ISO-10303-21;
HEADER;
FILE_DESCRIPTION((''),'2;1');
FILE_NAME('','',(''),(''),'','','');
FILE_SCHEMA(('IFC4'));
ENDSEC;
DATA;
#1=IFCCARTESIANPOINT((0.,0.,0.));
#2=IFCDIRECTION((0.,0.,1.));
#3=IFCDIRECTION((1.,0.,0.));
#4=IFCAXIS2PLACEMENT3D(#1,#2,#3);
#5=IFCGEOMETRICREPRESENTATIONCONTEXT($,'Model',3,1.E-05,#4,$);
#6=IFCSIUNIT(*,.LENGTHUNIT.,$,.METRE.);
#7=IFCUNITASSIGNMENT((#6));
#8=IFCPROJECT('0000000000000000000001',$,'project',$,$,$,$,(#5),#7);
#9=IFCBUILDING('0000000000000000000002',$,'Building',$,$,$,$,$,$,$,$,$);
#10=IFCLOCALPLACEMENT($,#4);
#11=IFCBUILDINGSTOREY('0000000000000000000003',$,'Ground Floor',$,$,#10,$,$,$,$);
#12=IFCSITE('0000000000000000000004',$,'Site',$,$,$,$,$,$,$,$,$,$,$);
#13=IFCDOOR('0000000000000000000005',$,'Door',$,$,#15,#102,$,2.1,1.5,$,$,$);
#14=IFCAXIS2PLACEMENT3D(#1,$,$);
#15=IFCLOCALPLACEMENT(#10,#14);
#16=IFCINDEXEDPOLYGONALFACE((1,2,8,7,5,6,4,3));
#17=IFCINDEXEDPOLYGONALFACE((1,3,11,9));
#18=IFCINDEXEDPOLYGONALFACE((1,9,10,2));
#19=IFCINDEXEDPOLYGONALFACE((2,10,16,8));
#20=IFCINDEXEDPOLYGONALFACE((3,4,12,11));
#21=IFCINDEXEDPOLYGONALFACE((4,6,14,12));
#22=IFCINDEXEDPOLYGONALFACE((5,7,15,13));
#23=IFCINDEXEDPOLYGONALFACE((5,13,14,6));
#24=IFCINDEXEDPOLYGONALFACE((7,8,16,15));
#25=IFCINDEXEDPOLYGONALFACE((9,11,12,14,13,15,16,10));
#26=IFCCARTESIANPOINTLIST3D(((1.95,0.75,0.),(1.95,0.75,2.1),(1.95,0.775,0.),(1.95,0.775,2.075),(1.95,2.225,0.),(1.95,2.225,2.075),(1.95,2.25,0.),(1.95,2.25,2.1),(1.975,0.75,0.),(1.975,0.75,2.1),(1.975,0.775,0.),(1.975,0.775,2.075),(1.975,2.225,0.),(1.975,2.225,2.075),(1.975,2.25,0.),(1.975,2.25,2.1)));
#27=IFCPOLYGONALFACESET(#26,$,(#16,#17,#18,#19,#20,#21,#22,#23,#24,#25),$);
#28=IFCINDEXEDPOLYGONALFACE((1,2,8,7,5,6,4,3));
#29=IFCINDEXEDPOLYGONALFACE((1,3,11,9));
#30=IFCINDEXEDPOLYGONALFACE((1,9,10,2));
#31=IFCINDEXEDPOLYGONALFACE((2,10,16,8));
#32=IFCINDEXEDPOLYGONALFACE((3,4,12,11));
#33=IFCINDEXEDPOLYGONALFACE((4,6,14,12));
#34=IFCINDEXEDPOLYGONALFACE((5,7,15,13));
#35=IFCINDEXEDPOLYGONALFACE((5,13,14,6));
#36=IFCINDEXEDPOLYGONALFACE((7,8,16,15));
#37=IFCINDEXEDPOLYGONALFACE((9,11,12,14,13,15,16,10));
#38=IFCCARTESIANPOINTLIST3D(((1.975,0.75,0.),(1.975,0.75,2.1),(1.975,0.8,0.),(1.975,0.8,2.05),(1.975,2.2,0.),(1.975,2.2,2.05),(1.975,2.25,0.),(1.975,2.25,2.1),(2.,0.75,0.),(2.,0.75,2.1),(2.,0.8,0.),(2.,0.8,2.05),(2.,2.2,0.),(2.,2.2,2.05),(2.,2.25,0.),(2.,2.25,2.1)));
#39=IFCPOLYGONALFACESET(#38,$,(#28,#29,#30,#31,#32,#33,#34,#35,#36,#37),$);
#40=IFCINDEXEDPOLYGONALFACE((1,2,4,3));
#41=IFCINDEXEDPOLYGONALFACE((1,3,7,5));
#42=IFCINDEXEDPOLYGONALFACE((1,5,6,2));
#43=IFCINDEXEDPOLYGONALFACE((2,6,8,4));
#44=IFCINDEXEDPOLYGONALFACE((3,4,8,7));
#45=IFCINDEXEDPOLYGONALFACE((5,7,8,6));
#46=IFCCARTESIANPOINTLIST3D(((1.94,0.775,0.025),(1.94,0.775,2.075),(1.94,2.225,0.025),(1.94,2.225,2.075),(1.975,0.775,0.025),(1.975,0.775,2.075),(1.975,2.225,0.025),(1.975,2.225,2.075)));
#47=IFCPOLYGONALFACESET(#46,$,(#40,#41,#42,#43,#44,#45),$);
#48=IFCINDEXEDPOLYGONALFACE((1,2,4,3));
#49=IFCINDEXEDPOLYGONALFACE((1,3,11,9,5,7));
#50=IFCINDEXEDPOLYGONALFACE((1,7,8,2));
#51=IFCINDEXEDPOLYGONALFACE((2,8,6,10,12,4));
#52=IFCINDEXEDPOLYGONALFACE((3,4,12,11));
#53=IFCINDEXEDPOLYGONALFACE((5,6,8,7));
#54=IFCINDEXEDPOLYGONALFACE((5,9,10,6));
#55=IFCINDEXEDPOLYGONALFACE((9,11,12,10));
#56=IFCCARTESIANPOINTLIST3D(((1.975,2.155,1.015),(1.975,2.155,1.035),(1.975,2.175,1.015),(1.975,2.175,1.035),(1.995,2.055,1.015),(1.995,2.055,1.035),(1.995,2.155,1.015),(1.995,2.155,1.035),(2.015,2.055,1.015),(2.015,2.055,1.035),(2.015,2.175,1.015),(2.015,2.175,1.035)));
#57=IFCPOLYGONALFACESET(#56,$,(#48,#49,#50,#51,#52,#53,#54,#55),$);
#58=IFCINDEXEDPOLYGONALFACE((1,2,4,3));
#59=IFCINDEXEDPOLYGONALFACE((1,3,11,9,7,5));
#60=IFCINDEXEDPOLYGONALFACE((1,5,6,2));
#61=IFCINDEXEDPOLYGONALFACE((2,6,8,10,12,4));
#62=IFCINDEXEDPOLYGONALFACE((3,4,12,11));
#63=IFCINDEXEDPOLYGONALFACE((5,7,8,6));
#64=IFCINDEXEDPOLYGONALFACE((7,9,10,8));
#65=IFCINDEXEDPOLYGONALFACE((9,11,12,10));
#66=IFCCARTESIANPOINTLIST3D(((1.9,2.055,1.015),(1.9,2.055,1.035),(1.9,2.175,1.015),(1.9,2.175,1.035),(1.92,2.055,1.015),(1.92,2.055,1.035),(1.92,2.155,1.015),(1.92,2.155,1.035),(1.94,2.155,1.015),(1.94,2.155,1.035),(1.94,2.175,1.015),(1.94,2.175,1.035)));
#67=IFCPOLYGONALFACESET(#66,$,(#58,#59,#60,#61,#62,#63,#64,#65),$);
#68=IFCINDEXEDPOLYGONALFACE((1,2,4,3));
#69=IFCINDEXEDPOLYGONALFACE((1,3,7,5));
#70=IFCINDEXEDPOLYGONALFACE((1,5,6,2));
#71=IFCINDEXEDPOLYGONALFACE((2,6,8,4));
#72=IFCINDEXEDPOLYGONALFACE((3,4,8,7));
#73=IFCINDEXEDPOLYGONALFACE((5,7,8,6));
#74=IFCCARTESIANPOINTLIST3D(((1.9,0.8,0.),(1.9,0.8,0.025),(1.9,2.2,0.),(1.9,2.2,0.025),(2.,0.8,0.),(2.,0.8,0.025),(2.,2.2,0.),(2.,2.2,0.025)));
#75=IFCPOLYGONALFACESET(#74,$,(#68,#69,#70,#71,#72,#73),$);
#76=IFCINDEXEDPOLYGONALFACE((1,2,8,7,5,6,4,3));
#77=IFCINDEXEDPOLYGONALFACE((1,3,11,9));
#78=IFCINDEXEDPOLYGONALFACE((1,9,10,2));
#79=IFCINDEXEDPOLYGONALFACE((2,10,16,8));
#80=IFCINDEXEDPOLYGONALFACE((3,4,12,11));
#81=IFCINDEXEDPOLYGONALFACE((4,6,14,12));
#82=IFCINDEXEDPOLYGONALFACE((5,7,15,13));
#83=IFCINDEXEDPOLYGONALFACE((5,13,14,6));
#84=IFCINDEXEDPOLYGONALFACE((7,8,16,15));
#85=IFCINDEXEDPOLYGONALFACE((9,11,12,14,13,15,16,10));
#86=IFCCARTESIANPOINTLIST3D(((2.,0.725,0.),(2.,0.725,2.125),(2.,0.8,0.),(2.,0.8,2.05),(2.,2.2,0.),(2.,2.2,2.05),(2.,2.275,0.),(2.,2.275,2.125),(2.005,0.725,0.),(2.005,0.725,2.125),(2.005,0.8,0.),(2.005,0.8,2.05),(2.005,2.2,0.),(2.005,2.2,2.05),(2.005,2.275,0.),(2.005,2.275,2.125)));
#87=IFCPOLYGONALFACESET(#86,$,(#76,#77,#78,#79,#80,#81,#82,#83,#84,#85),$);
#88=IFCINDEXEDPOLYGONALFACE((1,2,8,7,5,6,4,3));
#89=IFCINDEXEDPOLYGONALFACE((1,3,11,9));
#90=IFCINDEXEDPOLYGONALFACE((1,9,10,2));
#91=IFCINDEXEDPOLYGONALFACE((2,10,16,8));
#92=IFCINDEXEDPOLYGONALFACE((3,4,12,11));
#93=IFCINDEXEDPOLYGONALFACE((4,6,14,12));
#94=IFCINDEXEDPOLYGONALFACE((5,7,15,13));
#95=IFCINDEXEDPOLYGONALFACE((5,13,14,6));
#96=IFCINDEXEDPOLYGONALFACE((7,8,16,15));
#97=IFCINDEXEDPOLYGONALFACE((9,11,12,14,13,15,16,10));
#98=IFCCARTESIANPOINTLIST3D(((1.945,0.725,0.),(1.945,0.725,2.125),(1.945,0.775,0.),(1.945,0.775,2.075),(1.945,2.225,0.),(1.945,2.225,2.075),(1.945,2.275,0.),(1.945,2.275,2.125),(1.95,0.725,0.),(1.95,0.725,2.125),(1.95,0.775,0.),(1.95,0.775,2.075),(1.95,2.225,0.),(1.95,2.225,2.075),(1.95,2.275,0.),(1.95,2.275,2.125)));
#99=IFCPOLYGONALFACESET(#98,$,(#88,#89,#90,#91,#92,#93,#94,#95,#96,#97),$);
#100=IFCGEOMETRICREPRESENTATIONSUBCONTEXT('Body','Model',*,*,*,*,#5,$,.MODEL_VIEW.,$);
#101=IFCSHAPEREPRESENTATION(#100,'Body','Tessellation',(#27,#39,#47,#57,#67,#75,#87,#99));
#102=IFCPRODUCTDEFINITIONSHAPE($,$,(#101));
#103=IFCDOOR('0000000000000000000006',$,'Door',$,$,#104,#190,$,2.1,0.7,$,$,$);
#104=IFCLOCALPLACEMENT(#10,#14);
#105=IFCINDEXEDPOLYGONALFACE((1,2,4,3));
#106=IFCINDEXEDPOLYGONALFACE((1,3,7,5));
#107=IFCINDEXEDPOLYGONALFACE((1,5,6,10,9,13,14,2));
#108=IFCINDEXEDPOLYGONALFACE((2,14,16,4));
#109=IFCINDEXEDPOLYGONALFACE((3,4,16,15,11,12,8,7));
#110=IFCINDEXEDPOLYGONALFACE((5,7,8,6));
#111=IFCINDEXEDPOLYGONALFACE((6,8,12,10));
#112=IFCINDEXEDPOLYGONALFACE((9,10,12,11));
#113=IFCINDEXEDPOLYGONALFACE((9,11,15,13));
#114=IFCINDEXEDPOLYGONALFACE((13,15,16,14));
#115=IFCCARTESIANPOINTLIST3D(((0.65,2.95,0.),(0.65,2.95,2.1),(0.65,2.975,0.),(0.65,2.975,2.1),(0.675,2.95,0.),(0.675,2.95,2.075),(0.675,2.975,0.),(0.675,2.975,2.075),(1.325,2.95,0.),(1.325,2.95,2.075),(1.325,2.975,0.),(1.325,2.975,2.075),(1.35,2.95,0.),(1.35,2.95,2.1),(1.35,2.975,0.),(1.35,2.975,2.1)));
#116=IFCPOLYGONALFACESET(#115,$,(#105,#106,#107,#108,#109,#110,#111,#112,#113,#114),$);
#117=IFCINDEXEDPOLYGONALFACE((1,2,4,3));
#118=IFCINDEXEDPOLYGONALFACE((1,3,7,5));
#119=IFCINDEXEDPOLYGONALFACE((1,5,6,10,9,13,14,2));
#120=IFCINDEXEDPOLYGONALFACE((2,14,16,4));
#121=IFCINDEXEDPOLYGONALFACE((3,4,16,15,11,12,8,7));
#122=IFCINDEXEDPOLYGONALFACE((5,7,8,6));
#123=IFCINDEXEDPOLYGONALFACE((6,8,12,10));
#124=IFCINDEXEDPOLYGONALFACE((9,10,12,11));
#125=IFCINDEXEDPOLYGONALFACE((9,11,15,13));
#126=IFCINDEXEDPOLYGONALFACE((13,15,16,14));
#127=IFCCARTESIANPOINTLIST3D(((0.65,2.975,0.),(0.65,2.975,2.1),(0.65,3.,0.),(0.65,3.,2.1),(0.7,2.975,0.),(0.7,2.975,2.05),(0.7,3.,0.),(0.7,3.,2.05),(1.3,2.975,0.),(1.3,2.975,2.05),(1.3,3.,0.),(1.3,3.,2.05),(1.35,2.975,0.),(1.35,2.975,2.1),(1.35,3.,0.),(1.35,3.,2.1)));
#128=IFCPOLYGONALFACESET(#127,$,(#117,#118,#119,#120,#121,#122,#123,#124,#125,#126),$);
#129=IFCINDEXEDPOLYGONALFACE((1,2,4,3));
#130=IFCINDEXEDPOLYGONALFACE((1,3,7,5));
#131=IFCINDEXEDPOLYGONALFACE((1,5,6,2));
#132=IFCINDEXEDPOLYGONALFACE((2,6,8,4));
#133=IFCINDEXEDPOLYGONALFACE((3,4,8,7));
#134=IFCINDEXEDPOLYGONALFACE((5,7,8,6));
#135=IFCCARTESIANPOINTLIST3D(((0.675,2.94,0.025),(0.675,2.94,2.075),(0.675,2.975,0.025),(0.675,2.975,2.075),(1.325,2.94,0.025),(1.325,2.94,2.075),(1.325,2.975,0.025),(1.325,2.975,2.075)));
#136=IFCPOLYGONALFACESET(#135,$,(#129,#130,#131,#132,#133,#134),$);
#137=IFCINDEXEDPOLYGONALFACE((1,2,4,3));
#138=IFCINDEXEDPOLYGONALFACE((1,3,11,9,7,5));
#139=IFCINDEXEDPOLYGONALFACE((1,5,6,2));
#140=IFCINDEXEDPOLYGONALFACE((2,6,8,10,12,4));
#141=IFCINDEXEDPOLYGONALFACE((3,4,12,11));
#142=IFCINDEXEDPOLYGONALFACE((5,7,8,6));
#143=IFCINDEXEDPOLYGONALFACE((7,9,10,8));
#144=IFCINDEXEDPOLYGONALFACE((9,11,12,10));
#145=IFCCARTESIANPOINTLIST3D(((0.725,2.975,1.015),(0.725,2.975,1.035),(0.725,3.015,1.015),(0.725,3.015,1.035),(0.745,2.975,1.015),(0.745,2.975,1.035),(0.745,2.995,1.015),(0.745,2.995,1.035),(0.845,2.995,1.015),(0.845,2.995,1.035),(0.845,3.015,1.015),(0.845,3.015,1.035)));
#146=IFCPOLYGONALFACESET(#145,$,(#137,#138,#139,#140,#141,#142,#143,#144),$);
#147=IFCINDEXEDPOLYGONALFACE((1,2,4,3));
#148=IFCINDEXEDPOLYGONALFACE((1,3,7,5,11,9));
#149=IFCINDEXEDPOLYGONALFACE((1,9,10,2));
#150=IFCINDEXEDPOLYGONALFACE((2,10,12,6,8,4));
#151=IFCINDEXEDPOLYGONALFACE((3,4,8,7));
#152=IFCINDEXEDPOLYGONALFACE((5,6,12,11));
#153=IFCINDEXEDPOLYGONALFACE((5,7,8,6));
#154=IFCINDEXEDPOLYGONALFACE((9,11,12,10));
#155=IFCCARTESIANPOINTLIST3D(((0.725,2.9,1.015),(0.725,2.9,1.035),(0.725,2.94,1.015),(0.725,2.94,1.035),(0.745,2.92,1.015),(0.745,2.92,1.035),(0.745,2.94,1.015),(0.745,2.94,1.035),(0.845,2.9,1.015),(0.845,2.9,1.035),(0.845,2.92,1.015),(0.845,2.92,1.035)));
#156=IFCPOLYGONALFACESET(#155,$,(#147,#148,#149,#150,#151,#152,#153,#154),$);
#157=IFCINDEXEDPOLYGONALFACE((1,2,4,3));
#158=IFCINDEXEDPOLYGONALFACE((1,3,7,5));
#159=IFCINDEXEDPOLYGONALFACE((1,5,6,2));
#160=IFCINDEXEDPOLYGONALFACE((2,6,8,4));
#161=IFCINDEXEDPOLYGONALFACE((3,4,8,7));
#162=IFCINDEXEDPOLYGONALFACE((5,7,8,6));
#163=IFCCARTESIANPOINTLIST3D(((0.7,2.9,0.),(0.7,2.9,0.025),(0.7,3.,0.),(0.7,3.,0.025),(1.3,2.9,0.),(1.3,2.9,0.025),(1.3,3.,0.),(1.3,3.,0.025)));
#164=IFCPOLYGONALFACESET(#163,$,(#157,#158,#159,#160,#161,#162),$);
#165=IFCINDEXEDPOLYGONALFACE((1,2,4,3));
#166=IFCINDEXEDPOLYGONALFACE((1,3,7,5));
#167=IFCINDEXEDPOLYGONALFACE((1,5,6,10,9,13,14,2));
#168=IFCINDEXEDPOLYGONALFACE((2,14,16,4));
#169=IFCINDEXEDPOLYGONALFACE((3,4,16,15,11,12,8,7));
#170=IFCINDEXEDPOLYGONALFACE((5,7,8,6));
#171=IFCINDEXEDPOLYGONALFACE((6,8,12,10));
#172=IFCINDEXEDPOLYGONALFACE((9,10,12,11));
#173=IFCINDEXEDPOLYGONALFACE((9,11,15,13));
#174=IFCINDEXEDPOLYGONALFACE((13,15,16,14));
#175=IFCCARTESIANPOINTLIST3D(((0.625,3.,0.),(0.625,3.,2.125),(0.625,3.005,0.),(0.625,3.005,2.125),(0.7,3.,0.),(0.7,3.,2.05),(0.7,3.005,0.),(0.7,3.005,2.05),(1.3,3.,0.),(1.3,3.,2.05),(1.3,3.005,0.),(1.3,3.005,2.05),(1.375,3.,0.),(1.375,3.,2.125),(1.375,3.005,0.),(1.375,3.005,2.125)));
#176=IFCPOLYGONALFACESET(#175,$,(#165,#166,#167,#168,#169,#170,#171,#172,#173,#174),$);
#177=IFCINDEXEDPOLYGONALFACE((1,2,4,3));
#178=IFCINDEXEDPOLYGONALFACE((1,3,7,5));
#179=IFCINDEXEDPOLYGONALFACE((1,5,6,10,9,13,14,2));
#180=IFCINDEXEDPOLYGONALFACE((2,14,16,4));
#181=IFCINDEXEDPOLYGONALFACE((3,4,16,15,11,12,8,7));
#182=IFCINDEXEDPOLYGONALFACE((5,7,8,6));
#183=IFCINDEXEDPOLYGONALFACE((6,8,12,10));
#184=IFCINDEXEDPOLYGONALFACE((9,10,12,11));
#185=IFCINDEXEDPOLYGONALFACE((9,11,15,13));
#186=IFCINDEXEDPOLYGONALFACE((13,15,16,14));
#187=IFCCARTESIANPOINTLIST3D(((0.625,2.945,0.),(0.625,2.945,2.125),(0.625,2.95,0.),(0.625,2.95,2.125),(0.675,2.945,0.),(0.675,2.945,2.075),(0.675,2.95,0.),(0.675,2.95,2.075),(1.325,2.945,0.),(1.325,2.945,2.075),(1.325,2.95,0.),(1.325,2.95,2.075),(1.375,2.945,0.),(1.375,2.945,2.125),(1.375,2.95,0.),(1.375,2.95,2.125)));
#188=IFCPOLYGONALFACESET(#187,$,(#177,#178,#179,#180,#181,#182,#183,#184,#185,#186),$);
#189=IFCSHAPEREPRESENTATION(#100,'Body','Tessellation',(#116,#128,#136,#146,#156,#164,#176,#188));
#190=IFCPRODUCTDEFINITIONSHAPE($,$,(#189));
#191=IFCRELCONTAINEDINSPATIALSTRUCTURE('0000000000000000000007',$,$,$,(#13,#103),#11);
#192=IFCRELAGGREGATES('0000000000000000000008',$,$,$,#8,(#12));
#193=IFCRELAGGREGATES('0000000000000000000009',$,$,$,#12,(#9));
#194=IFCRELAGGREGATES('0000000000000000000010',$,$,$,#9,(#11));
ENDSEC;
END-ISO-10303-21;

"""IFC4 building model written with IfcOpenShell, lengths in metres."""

from ifc_helpers import new_model, si_unit, frame, origin_with_axes, place, context, subcontext, project, spatial, line, indexed_curve, outline, extrude, element, save


model = new_model("IFC4")

# Units and contexts
model_context = context("Model", 3, precision=1e-05, world=origin_with_axes())
body_context = subcontext(model_context, "Body", "Model", "MODEL_VIEW")
ifc_project = project(units=[si_unit("LENGTHUNIT", "METRE")], contexts=[model_context])

# Site, building, storey
site = spatial("IfcSite", under=ifc_project, Name="Site")
building = spatial("IfcBuilding", under=site, Name="Building")
storey_placement = place(None, origin_with_axes())
storey = spatial("IfcBuildingStorey", under=building, at=storey_placement, Name="Ground Floor")

# Doors
door_1_placement = place(storey_placement, frame((2.0, 0.75, 0.0), z_axis=(0.0, 0.0, 1.0), x_axis=(0.0, 1.0, 0.0)))
element("IfcDoor", 1, at=door_1_placement, inside=storey, Name="Door", OverallHeight=2.1, OverallWidth=1.5, context=body_context, shape_type="SweptSolid", body=[
    extrude(outline(indexed_curve([(0.0, 0.0), (0.0, 2.1), (1.5, 2.1), (1.5, 0.0), (1.475, 0.0), (1.475, 2.075), (0.025, 2.075), (0.025, 0.0)], segments=[line(1, 2, 3, 4, 5, 6, 7, 8, 1)])), frame((0.0, 0.025, 0.0), z_axis=(0.0, -1.0, 0.0), x_axis=(1.0, 0.0, 0.0)), (0.0, 0.0, -1.0), 0.025),
    extrude(outline(indexed_curve([(0.0, 0.0), (0.0, 2.1), (1.5, 2.1), (1.5, 0.0), (1.45, 0.0), (1.45, 2.05), (0.05, 2.05), (0.05, 0.0)], segments=[line(1, 2, 3, 4, 5, 6, 7, 8, 1)])), frame((0.0, 0.0, 0.0), z_axis=(0.0, -1.0, 0.0), x_axis=(1.0, 0.0, 0.0)), (0.0, 0.0, -1.0), 0.025),
    extrude(outline(indexed_curve([(0.0, 0.0), (1.45, 0.0), (1.45, 0.035), (0.0, 0.035)], segments=[line(1, 2, 3, 4, 1)])), frame((0.025, 0.025, 0.025), z_axis=(0.0, 0.0, 1.0), x_axis=(1.0, 0.0, 0.0)), (0.0, 0.0, 1.0), 2.05),
    extrude(outline(indexed_curve([(0.0, 0.0), (0.0, -0.04), (-0.12, -0.04), (-0.12, -0.02), (-0.02, -0.02), (-0.02, 0.0)], segments=[line(1, 2, 3, 4, 5, 6, 1)])), frame((1.425, 0.025, 1.015), z_axis=(0.0, 0.0, 1.0), x_axis=(1.0, 0.0, 0.0)), (0.0, 0.0, 1.0), 0.02),
    extrude(outline(indexed_curve([(0.0, 0.0), (0.0, 0.04), (-0.12, 0.04), (-0.12, 0.02), (-0.02, 0.02), (-0.02, 0.0)], segments=[line(1, 2, 3, 4, 5, 6, 1)])), frame((1.425, 0.06, 1.015), z_axis=(0.0, 0.0, 1.0), x_axis=(1.0, 0.0, 0.0)), (0.0, 0.0, 1.0), 0.02),
    extrude(outline(indexed_curve([(0.0, 0.0), (1.4, 0.0), (1.4, 0.1), (0.0, 0.1)], segments=[line(1, 2, 3, 4, 1)])), frame((0.05, 0.0, 0.0), z_axis=(0.0, 0.0, 1.0), x_axis=(1.0, 0.0, 0.0)), (0.0, 0.0, 1.0), 0.025),
    extrude(outline(indexed_curve([(0.0, 0.0), (0.0, 2.125), (1.55, 2.125), (1.55, 0.0), (1.475, 0.0), (1.475, 2.05), (0.075, 2.05), (0.075, 0.0)], segments=[line(1, 2, 3, 4, 5, 6, 7, 8, 1)])), frame((-0.025, -0.005, 0.0), z_axis=(0.0, -1.0, 0.0), x_axis=(1.0, 0.0, 0.0)), (0.0, 0.0, -1.0), 0.005),
    extrude(outline(indexed_curve([(0.0, 0.0), (0.0, 2.125), (1.55, 2.125), (1.55, 0.0), (1.5, 0.0), (1.5, 2.075), (0.05, 2.075), (0.05, 0.0)], segments=[line(1, 2, 3, 4, 5, 6, 7, 8, 1)])), frame((-0.025, 0.05, 0.0), z_axis=(0.0, -1.0, 0.0), x_axis=(1.0, 0.0, 0.0)), (0.0, 0.0, -1.0), 0.005),
])
door_2_placement = place(storey_placement, frame((1.35, 3.0, 0.0), z_axis=(0.0, 0.0, 1.0), x_axis=(-1.0, 0.0, 0.0)))
element("IfcDoor", 2, at=door_2_placement, inside=storey, Name="Door", OverallHeight=2.1, OverallWidth=0.7, context=body_context, shape_type="SweptSolid", body=[
    extrude(outline(indexed_curve([(0.0, 0.0), (0.0, 2.1), (0.7, 2.1), (0.7, 0.0), (0.675, 0.0), (0.675, 2.075), (0.025, 2.075), (0.025, 0.0)], segments=[line(1, 2, 3, 4, 5, 6, 7, 8, 1)])), frame((0.0, 0.025, 0.0), z_axis=(0.0, -1.0, 0.0), x_axis=(1.0, 0.0, 0.0)), (0.0, 0.0, -1.0), 0.025),
    extrude(outline(indexed_curve([(0.0, 0.0), (0.0, 2.1), (0.7, 2.1), (0.7, 0.0), (0.65, 0.0), (0.65, 2.05), (0.05, 2.05), (0.05, 0.0)], segments=[line(1, 2, 3, 4, 5, 6, 7, 8, 1)])), frame((0.0, 0.0, 0.0), z_axis=(0.0, -1.0, 0.0), x_axis=(1.0, 0.0, 0.0)), (0.0, 0.0, -1.0), 0.025),
    extrude(outline(indexed_curve([(0.0, 0.0), (0.65, 0.0), (0.65, 0.035), (0.0, 0.035)], segments=[line(1, 2, 3, 4, 1)])), frame((0.025, 0.025, 0.025), z_axis=(0.0, 0.0, 1.0), x_axis=(1.0, 0.0, 0.0)), (0.0, 0.0, 1.0), 2.05),
    extrude(outline(indexed_curve([(0.0, 0.0), (0.0, -0.04), (-0.12, -0.04), (-0.12, -0.02), (-0.02, -0.02), (-0.02, 0.0)], segments=[line(1, 2, 3, 4, 5, 6, 1)])), frame((0.625, 0.025, 1.015), z_axis=(0.0, 0.0, 1.0), x_axis=(1.0, 0.0, 0.0)), (0.0, 0.0, 1.0), 0.02),
    extrude(outline(indexed_curve([(0.0, 0.0), (0.0, 0.04), (-0.12, 0.04), (-0.12, 0.02), (-0.02, 0.02), (-0.02, 0.0)], segments=[line(1, 2, 3, 4, 5, 6, 1)])), frame((0.625, 0.06, 1.015), z_axis=(0.0, 0.0, 1.0), x_axis=(1.0, 0.0, 0.0)), (0.0, 0.0, 1.0), 0.02),
    extrude(outline(indexed_curve([(0.0, 0.0), (0.6, 0.0), (0.6, 0.1), (0.0, 0.1)], segments=[line(1, 2, 3, 4, 1)])), frame((0.05, 0.0, 0.0), z_axis=(0.0, 0.0, 1.0), x_axis=(1.0, 0.0, 0.0)), (0.0, 0.0, 1.0), 0.025),
    extrude(outline(indexed_curve([(0.0, 0.0), (0.0, 2.125), (0.75, 2.125), (0.75, 0.0), (0.675, 0.0), (0.675, 2.05), (0.075, 2.05), (0.075, 0.0)], segments=[line(1, 2, 3, 4, 5, 6, 7, 8, 1)])), frame((-0.025, -0.005, 0.0), z_axis=(0.0, -1.0, 0.0), x_axis=(1.0, 0.0, 0.0)), (0.0, 0.0, -1.0), 0.005),
    extrude(outline(indexed_curve([(0.0, 0.0), (0.0, 2.125), (0.75, 2.125), (0.75, 0.0), (0.7, 0.0), (0.7, 2.075), (0.05, 2.075), (0.05, 0.0)], segments=[line(1, 2, 3, 4, 5, 6, 7, 8, 1)])), frame((-0.025, 0.05, 0.0), z_axis=(0.0, -1.0, 0.0), x_axis=(1.0, 0.0, 0.0)), (0.0, 0.0, -1.0), 0.005),
])

save(model, "model.ifc")
